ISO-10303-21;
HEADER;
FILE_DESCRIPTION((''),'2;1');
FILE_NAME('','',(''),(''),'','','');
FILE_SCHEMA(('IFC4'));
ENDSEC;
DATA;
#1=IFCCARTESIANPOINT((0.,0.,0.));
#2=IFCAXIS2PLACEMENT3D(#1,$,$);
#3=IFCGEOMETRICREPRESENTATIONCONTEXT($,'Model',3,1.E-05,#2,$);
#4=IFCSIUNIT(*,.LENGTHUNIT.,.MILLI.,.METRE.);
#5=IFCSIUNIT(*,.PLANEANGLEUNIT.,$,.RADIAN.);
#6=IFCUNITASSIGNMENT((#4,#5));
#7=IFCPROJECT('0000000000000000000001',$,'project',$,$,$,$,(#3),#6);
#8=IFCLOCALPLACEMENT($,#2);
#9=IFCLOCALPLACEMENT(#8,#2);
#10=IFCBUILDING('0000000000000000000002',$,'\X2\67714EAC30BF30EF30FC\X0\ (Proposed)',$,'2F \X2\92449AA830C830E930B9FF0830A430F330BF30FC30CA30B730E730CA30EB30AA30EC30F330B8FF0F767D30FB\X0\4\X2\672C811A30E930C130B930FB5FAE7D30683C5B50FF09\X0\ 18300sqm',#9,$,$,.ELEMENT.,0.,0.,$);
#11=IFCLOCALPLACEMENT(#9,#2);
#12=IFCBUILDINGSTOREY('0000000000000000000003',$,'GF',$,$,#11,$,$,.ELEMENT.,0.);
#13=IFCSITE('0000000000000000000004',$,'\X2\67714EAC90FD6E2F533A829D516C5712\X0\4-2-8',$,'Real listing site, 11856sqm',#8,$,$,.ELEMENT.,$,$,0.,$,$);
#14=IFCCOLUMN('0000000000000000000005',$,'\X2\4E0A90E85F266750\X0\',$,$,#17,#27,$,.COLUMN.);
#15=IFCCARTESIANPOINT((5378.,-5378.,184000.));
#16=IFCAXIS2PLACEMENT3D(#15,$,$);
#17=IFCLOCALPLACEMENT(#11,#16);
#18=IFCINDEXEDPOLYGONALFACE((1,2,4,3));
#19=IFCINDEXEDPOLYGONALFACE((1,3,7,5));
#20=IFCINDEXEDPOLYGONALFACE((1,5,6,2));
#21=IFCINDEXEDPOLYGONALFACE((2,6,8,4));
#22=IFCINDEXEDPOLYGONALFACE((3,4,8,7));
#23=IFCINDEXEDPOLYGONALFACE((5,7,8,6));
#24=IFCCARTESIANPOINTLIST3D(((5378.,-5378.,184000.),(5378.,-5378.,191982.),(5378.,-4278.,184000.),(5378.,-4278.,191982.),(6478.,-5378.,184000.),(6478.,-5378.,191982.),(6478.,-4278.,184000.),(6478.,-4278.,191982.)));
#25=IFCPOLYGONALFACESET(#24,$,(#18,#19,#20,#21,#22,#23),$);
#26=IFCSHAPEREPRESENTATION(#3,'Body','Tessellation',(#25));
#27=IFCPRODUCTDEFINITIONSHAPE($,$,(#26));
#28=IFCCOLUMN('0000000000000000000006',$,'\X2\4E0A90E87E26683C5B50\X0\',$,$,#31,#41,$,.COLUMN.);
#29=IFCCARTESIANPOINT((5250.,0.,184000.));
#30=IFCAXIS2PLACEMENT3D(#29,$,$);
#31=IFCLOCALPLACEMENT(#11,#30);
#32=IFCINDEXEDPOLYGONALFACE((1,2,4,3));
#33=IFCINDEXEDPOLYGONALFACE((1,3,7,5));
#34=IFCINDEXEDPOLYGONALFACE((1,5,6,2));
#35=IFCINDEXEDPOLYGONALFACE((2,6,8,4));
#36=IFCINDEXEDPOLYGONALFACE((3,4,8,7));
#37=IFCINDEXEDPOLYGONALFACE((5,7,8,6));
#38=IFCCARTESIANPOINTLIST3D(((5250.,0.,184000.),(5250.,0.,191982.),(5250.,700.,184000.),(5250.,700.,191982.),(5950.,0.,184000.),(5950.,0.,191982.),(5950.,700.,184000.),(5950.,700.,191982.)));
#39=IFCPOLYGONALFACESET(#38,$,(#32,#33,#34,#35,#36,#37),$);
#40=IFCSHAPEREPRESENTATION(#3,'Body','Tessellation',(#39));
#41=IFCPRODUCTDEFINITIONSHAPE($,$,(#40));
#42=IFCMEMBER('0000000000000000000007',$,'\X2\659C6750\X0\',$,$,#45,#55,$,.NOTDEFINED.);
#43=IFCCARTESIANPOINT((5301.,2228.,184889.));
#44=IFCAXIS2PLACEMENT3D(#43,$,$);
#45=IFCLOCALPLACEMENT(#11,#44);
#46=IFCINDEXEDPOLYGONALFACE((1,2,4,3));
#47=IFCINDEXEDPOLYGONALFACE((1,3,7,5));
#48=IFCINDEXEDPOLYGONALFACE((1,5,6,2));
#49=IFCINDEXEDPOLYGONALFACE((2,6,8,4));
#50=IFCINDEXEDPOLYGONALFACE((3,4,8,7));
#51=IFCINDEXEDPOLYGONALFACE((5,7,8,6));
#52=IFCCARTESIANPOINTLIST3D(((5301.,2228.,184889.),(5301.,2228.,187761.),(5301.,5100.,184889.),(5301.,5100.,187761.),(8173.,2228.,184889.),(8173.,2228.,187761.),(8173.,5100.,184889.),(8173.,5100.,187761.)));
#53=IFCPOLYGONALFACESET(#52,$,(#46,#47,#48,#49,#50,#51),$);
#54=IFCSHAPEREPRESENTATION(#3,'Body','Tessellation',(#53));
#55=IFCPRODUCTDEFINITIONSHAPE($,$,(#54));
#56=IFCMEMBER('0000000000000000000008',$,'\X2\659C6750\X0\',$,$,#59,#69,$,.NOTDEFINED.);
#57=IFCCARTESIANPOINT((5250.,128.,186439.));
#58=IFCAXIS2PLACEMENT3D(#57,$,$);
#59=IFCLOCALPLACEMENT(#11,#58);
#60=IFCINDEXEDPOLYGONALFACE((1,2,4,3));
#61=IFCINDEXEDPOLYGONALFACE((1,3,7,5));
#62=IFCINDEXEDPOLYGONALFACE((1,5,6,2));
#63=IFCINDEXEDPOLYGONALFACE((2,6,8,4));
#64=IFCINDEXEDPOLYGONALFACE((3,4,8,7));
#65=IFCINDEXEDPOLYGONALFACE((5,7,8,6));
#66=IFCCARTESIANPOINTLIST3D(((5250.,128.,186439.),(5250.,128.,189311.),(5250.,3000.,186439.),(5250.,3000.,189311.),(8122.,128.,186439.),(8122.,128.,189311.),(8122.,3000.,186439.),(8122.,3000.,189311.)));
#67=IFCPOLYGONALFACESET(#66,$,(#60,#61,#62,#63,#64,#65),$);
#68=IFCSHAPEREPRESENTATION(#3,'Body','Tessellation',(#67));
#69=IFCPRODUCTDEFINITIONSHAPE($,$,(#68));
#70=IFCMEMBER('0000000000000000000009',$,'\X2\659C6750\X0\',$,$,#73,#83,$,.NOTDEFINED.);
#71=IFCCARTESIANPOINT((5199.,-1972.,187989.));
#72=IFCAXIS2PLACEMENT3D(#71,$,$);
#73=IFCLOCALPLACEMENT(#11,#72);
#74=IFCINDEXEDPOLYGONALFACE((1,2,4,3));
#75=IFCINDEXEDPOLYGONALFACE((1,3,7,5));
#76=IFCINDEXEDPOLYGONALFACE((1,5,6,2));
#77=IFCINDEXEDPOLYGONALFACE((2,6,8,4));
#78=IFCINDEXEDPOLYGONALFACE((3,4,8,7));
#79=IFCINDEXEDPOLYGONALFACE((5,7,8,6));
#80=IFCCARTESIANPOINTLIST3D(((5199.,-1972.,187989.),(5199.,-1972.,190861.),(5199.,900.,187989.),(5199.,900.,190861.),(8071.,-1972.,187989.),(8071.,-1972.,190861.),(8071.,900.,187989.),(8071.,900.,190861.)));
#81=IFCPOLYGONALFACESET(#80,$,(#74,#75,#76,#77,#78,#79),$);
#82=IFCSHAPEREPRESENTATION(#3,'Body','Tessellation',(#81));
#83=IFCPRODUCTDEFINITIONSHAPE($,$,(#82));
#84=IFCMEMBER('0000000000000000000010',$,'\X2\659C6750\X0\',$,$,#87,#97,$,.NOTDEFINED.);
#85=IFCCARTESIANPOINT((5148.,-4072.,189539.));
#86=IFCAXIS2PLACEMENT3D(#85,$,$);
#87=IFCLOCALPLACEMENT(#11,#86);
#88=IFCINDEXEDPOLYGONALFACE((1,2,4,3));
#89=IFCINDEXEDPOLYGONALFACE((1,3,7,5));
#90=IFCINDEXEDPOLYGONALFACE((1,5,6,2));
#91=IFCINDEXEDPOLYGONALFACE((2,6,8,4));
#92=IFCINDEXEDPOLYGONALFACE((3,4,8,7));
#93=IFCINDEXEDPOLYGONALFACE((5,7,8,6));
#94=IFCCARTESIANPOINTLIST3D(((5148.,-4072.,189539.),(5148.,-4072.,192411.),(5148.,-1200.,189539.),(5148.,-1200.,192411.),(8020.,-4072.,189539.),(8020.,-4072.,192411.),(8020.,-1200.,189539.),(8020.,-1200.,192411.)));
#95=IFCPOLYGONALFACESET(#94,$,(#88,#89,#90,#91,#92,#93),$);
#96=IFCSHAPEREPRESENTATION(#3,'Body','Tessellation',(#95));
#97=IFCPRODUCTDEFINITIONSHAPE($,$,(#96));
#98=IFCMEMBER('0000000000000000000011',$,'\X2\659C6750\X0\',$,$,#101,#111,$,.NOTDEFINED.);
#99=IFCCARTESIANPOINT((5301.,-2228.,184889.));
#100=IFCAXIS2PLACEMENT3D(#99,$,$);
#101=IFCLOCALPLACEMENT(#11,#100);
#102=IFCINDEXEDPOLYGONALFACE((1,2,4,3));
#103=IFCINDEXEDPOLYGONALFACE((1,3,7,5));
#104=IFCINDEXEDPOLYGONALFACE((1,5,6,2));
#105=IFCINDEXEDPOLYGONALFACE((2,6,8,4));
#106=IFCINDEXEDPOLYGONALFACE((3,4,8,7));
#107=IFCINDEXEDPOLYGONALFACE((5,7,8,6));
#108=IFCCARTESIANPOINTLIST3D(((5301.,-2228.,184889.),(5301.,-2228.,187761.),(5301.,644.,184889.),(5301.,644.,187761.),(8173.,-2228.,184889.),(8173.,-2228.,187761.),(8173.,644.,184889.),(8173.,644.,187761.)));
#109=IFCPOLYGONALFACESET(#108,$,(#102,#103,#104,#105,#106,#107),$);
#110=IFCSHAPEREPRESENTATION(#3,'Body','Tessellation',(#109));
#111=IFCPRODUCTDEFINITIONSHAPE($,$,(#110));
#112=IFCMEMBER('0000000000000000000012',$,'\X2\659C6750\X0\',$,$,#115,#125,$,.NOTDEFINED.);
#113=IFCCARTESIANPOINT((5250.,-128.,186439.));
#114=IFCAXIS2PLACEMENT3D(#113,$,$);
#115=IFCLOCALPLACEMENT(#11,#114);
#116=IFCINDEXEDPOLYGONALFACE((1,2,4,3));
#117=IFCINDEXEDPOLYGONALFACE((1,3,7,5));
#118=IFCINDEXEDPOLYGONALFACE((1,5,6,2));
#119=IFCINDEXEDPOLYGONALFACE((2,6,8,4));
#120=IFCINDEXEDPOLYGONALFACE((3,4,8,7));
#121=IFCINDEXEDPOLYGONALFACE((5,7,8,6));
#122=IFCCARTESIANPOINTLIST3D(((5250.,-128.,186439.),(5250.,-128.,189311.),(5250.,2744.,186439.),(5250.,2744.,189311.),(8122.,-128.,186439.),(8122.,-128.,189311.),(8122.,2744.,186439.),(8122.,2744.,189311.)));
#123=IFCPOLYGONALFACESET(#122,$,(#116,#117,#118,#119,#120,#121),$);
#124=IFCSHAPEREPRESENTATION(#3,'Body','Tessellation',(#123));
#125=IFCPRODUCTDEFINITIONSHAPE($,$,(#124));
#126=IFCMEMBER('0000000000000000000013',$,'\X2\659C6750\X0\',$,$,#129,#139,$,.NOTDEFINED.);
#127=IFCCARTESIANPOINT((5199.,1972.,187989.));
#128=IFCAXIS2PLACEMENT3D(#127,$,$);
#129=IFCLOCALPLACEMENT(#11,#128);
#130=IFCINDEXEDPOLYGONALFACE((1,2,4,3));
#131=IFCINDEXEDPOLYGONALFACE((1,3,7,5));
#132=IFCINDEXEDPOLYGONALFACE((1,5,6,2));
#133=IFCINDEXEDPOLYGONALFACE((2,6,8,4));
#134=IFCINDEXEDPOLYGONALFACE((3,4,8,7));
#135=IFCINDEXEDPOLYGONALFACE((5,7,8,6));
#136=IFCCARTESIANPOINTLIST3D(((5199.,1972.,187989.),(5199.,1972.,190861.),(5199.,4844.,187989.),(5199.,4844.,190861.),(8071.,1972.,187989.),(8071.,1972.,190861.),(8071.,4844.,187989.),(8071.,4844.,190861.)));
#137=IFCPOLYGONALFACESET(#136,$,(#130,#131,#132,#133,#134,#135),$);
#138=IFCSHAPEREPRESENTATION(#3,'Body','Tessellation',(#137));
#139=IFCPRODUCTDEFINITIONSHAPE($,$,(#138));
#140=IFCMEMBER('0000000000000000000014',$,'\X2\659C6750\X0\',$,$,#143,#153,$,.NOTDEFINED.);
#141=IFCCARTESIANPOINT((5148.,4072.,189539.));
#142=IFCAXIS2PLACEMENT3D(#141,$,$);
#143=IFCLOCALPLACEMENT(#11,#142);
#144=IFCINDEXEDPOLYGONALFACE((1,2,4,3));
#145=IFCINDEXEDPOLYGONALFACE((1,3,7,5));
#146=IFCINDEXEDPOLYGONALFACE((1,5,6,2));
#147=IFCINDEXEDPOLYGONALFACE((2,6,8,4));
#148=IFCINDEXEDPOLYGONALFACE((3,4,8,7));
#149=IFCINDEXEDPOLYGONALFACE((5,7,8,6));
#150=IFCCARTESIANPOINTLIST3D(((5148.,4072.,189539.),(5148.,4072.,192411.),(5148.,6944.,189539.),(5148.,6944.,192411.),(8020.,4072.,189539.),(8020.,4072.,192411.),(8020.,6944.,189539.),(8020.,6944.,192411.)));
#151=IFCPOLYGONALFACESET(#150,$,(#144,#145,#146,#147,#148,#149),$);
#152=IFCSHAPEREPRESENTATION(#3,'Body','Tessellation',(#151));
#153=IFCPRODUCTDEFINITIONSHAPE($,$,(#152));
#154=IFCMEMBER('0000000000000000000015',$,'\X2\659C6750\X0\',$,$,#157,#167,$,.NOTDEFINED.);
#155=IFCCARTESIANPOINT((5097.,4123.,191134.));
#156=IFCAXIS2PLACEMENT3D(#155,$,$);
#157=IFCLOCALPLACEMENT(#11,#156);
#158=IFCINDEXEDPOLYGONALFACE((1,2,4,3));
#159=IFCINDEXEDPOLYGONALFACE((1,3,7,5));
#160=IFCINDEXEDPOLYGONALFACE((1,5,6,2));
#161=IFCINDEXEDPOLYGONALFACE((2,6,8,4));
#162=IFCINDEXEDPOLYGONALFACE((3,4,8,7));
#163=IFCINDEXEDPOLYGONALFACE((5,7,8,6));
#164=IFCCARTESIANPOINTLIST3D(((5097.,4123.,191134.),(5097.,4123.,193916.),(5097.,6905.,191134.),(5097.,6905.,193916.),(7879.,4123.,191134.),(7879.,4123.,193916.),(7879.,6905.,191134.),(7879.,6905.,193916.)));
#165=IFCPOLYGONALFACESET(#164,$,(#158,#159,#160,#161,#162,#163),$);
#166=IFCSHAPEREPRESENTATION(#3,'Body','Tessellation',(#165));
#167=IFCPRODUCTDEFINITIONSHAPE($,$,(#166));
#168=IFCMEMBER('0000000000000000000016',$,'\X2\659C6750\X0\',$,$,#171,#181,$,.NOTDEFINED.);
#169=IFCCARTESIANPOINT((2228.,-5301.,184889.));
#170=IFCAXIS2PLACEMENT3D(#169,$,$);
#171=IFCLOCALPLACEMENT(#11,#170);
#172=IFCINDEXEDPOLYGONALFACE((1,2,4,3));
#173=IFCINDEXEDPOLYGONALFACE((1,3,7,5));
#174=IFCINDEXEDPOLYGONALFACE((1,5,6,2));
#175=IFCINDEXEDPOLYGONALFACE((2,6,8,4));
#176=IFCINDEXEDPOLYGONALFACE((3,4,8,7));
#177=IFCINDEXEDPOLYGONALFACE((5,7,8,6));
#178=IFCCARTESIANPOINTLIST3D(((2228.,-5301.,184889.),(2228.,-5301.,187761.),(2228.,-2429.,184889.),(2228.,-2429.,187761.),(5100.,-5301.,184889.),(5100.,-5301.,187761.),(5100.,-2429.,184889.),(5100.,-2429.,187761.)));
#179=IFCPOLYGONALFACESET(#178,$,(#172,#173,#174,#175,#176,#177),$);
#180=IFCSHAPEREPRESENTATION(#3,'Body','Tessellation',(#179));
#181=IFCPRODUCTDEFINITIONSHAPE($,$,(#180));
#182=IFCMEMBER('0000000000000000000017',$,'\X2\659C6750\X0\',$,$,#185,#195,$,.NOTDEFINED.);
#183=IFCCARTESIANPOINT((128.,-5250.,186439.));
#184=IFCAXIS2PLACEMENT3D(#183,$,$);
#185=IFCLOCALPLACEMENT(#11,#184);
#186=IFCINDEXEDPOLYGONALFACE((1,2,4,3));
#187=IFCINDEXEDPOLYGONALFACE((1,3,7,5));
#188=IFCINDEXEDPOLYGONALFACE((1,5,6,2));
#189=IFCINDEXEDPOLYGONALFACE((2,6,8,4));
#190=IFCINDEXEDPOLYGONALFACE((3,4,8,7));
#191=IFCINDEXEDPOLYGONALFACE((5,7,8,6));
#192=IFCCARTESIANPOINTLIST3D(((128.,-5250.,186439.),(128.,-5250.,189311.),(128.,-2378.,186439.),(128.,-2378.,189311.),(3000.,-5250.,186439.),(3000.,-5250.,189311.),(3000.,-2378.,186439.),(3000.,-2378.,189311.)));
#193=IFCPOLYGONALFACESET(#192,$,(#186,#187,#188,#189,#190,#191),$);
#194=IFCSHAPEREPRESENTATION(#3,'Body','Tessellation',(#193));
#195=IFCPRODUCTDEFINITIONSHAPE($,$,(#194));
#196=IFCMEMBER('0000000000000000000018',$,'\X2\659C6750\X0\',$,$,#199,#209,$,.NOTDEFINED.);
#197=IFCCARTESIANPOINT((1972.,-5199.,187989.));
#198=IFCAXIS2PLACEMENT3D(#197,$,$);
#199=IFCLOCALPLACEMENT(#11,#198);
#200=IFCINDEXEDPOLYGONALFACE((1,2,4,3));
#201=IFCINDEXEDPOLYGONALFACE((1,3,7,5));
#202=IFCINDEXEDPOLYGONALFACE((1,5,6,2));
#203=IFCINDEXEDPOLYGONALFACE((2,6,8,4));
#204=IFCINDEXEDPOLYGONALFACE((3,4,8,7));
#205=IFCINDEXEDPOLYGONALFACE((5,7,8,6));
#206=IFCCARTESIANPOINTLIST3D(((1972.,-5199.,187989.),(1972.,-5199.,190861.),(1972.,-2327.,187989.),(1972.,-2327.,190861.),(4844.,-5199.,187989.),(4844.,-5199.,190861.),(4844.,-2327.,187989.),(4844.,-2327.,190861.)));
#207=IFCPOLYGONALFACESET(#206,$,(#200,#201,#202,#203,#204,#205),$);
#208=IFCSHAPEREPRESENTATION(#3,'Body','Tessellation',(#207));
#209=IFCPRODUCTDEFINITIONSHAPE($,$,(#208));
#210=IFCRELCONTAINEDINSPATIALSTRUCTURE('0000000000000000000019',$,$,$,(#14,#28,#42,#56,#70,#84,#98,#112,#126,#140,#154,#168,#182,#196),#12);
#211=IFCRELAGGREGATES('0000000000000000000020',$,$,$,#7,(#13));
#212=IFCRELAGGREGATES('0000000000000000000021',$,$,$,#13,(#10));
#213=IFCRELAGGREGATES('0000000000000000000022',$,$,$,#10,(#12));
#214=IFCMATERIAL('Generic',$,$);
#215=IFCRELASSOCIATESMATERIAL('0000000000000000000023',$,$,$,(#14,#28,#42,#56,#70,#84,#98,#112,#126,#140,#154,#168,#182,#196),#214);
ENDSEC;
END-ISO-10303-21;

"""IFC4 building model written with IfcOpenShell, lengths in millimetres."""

from ifc_helpers import new_model, si_unit, frame, frame_2d, origin, place, context, project, spatial, rectangle, extrude, material, element, save


model = new_model("IFC4")

# Units and contexts
model_context = context("Model", 3, precision=1e-05, world=origin())
ifc_project = project(units=[si_unit("LENGTHUNIT", "METRE", prefix="MILLI"), si_unit("PLANEANGLEUNIT", "RADIAN")], contexts=[model_context])

# Site, building, storey
site_placement = place(None, origin())
site = spatial("IfcSite", under=ifc_project, at=site_placement, Name="東京都港区芝公園4-2-8", ObjectType="Real listing site, 11856sqm", CompositionType="ELEMENT", RefElevation=0.0)
building_placement = place(site_placement, origin())
building = spatial("IfcBuilding", under=site, at=building_placement, Name="東京タワー (Proposed)", ObjectType="2F 鉄骨トラス（インターナショナルオレンジ／白・4本脚ラチス・微細格子） 18300sqm", CompositionType="ELEMENT", ElevationOfRefHeight=0.0, ElevationOfTerrain=0.0)
storey_placement = place(building_placement, origin())
storey = spatial("IfcBuildingStorey", under=building, at=storey_placement, Name="GF", CompositionType="ELEMENT", Elevation=0.0)

# Columns
ifc_material = material(Name="Generic")
column_1_placement = place(storey_placement, frame((5378.0, -5378.0, 184000.0)))
element("IfcColumn", 1, at=column_1_placement, inside=storey, material=ifc_material, Name="上部弦材", PredefinedType="COLUMN", context=model_context, shape_type="SweptSolid", body=[
    extrude(rectangle(XDim=1100.0, YDim=1100.0, at=frame_2d((550.0, 550.0))), frame((5378.0, -5378.0, 184000.0)), (0.0, 0.0, 1.0), 7982.0),
])
column_2_placement = place(storey_placement, frame((5250.0, 0.0, 184000.0)))
element("IfcColumn", 2, at=column_2_placement, inside=storey, material=ifc_material, Name="上部縦格子", PredefinedType="COLUMN", context=model_context, shape_type="SweptSolid", body=[
    extrude(rectangle(XDim=700.0, YDim=700.0, at=frame_2d((350.0, 350.0))), frame((5250.0, 0.0, 184000.0)), (0.0, 0.0, 1.0), 7982.0),
])

# Members
member_1_placement = place(storey_placement, frame((5301.0, 2228.0, 184889.0)))
element("IfcMember", 3, at=member_1_placement, inside=storey, material=ifc_material, Name="斜材", PredefinedType="NOTDEFINED", context=model_context, shape_type="SweptSolid", body=[
    extrude(rectangle(XDim=2872.0, YDim=2872.0, at=frame_2d((1436.0, 1436.0))), frame((5301.0, 2228.0, 184889.0)), (0.0, 0.0, 1.0), 2872.0),
])
member_2_placement = place(storey_placement, frame((5250.0, 128.0, 186439.0)))
element("IfcMember", 4, at=member_2_placement, inside=storey, material=ifc_material, Name="斜材", PredefinedType="NOTDEFINED", context=model_context, shape_type="SweptSolid", body=[
    extrude(rectangle(XDim=2872.0, YDim=2872.0, at=frame_2d((1436.0, 1436.0))), frame((5250.0, 128.0, 186439.0)), (0.0, 0.0, 1.0), 2872.0),
])
member_3_placement = place(storey_placement, frame((5199.0, -1972.0, 187989.0)))
element("IfcMember", 5, at=member_3_placement, inside=storey, material=ifc_material, Name="斜材", PredefinedType="NOTDEFINED", context=model_context, shape_type="SweptSolid", body=[
    extrude(rectangle(XDim=2872.0, YDim=2872.0, at=frame_2d((1436.0, 1436.0))), frame((5199.0, -1972.0, 187989.0)), (0.0, 0.0, 1.0), 2872.0),
])
member_4_placement = place(storey_placement, frame((5148.0, -4072.0, 189539.0)))
element("IfcMember", 6, at=member_4_placement, inside=storey, material=ifc_material, Name="斜材", PredefinedType="NOTDEFINED", context=model_context, shape_type="SweptSolid", body=[
    extrude(rectangle(XDim=2872.0, YDim=2872.0, at=frame_2d((1436.0, 1436.0))), frame((5148.0, -4072.0, 189539.0)), (0.0, 0.0, 1.0), 2872.0),
])
member_5_placement = place(storey_placement, frame((5301.0, -2228.0, 184889.0)))
element("IfcMember", 7, at=member_5_placement, inside=storey, material=ifc_material, Name="斜材", PredefinedType="NOTDEFINED", context=model_context, shape_type="SweptSolid", body=[
    extrude(rectangle(XDim=2872.0, YDim=2872.0, at=frame_2d((1436.0, 1436.0))), frame((5301.0, -2228.0, 184889.0)), (0.0, 0.0, 1.0), 2872.0),
])
member_6_placement = place(storey_placement, frame((5250.0, -128.0, 186439.0)))
element("IfcMember", 8, at=member_6_placement, inside=storey, material=ifc_material, Name="斜材", PredefinedType="NOTDEFINED", context=model_context, shape_type="SweptSolid", body=[
    extrude(rectangle(XDim=2872.0, YDim=2872.0, at=frame_2d((1436.0, 1436.0))), frame((5250.0, -128.0, 186439.0)), (0.0, 0.0, 1.0), 2872.0),
])
member_7_placement = place(storey_placement, frame((5199.0, 1972.0, 187989.0)))
element("IfcMember", 9, at=member_7_placement, inside=storey, material=ifc_material, Name="斜材", PredefinedType="NOTDEFINED", context=model_context, shape_type="SweptSolid", body=[
    extrude(rectangle(XDim=2872.0, YDim=2872.0, at=frame_2d((1436.0, 1436.0))), frame((5199.0, 1972.0, 187989.0)), (0.0, 0.0, 1.0), 2872.0),
])
member_8_placement = place(storey_placement, frame((5148.0, 4072.0, 189539.0)))
element("IfcMember", 10, at=member_8_placement, inside=storey, material=ifc_material, Name="斜材", PredefinedType="NOTDEFINED", context=model_context, shape_type="SweptSolid", body=[
    extrude(rectangle(XDim=2872.0, YDim=2872.0, at=frame_2d((1436.0, 1436.0))), frame((5148.0, 4072.0, 189539.0)), (0.0, 0.0, 1.0), 2872.0),
])
member_9_placement = place(storey_placement, frame((5097.0, 4123.0, 191134.0)))
element("IfcMember", 11, at=member_9_placement, inside=storey, material=ifc_material, Name="斜材", PredefinedType="NOTDEFINED", context=model_context, shape_type="SweptSolid", body=[
    extrude(rectangle(XDim=2782.0, YDim=2782.0, at=frame_2d((1391.0, 1391.0))), frame((5097.0, 4123.0, 191134.0)), (0.0, 0.0, 1.0), 2782.0),
])
member_10_placement = place(storey_placement, frame((2228.0, -5301.0, 184889.0)))
element("IfcMember", 12, at=member_10_placement, inside=storey, material=ifc_material, Name="斜材", PredefinedType="NOTDEFINED", context=model_context, shape_type="SweptSolid", body=[
    extrude(rectangle(XDim=2872.0, YDim=2872.0, at=frame_2d((1436.0, 1436.0))), frame((2228.0, -5301.0, 184889.0)), (0.0, 0.0, 1.0), 2872.0),
])
member_11_placement = place(storey_placement, frame((128.0, -5250.0, 186439.0)))
element("IfcMember", 13, at=member_11_placement, inside=storey, material=ifc_material, Name="斜材", PredefinedType="NOTDEFINED", context=model_context, shape_type="SweptSolid", body=[
    extrude(rectangle(XDim=2872.0, YDim=2872.0, at=frame_2d((1436.0, 1436.0))), frame((128.0, -5250.0, 186439.0)), (0.0, 0.0, 1.0), 2872.0),
])
member_12_placement = place(storey_placement, frame((1972.0, -5199.0, 187989.0)))
element("IfcMember", 14, at=member_12_placement, inside=storey, material=ifc_material, Name="斜材", PredefinedType="NOTDEFINED", context=model_context, shape_type="SweptSolid", body=[
    extrude(rectangle(XDim=2872.0, YDim=2872.0, at=frame_2d((1436.0, 1436.0))), frame((1972.0, -5199.0, 187989.0)), (0.0, 0.0, 1.0), 2872.0),
])

save(model, "model.ifc")
